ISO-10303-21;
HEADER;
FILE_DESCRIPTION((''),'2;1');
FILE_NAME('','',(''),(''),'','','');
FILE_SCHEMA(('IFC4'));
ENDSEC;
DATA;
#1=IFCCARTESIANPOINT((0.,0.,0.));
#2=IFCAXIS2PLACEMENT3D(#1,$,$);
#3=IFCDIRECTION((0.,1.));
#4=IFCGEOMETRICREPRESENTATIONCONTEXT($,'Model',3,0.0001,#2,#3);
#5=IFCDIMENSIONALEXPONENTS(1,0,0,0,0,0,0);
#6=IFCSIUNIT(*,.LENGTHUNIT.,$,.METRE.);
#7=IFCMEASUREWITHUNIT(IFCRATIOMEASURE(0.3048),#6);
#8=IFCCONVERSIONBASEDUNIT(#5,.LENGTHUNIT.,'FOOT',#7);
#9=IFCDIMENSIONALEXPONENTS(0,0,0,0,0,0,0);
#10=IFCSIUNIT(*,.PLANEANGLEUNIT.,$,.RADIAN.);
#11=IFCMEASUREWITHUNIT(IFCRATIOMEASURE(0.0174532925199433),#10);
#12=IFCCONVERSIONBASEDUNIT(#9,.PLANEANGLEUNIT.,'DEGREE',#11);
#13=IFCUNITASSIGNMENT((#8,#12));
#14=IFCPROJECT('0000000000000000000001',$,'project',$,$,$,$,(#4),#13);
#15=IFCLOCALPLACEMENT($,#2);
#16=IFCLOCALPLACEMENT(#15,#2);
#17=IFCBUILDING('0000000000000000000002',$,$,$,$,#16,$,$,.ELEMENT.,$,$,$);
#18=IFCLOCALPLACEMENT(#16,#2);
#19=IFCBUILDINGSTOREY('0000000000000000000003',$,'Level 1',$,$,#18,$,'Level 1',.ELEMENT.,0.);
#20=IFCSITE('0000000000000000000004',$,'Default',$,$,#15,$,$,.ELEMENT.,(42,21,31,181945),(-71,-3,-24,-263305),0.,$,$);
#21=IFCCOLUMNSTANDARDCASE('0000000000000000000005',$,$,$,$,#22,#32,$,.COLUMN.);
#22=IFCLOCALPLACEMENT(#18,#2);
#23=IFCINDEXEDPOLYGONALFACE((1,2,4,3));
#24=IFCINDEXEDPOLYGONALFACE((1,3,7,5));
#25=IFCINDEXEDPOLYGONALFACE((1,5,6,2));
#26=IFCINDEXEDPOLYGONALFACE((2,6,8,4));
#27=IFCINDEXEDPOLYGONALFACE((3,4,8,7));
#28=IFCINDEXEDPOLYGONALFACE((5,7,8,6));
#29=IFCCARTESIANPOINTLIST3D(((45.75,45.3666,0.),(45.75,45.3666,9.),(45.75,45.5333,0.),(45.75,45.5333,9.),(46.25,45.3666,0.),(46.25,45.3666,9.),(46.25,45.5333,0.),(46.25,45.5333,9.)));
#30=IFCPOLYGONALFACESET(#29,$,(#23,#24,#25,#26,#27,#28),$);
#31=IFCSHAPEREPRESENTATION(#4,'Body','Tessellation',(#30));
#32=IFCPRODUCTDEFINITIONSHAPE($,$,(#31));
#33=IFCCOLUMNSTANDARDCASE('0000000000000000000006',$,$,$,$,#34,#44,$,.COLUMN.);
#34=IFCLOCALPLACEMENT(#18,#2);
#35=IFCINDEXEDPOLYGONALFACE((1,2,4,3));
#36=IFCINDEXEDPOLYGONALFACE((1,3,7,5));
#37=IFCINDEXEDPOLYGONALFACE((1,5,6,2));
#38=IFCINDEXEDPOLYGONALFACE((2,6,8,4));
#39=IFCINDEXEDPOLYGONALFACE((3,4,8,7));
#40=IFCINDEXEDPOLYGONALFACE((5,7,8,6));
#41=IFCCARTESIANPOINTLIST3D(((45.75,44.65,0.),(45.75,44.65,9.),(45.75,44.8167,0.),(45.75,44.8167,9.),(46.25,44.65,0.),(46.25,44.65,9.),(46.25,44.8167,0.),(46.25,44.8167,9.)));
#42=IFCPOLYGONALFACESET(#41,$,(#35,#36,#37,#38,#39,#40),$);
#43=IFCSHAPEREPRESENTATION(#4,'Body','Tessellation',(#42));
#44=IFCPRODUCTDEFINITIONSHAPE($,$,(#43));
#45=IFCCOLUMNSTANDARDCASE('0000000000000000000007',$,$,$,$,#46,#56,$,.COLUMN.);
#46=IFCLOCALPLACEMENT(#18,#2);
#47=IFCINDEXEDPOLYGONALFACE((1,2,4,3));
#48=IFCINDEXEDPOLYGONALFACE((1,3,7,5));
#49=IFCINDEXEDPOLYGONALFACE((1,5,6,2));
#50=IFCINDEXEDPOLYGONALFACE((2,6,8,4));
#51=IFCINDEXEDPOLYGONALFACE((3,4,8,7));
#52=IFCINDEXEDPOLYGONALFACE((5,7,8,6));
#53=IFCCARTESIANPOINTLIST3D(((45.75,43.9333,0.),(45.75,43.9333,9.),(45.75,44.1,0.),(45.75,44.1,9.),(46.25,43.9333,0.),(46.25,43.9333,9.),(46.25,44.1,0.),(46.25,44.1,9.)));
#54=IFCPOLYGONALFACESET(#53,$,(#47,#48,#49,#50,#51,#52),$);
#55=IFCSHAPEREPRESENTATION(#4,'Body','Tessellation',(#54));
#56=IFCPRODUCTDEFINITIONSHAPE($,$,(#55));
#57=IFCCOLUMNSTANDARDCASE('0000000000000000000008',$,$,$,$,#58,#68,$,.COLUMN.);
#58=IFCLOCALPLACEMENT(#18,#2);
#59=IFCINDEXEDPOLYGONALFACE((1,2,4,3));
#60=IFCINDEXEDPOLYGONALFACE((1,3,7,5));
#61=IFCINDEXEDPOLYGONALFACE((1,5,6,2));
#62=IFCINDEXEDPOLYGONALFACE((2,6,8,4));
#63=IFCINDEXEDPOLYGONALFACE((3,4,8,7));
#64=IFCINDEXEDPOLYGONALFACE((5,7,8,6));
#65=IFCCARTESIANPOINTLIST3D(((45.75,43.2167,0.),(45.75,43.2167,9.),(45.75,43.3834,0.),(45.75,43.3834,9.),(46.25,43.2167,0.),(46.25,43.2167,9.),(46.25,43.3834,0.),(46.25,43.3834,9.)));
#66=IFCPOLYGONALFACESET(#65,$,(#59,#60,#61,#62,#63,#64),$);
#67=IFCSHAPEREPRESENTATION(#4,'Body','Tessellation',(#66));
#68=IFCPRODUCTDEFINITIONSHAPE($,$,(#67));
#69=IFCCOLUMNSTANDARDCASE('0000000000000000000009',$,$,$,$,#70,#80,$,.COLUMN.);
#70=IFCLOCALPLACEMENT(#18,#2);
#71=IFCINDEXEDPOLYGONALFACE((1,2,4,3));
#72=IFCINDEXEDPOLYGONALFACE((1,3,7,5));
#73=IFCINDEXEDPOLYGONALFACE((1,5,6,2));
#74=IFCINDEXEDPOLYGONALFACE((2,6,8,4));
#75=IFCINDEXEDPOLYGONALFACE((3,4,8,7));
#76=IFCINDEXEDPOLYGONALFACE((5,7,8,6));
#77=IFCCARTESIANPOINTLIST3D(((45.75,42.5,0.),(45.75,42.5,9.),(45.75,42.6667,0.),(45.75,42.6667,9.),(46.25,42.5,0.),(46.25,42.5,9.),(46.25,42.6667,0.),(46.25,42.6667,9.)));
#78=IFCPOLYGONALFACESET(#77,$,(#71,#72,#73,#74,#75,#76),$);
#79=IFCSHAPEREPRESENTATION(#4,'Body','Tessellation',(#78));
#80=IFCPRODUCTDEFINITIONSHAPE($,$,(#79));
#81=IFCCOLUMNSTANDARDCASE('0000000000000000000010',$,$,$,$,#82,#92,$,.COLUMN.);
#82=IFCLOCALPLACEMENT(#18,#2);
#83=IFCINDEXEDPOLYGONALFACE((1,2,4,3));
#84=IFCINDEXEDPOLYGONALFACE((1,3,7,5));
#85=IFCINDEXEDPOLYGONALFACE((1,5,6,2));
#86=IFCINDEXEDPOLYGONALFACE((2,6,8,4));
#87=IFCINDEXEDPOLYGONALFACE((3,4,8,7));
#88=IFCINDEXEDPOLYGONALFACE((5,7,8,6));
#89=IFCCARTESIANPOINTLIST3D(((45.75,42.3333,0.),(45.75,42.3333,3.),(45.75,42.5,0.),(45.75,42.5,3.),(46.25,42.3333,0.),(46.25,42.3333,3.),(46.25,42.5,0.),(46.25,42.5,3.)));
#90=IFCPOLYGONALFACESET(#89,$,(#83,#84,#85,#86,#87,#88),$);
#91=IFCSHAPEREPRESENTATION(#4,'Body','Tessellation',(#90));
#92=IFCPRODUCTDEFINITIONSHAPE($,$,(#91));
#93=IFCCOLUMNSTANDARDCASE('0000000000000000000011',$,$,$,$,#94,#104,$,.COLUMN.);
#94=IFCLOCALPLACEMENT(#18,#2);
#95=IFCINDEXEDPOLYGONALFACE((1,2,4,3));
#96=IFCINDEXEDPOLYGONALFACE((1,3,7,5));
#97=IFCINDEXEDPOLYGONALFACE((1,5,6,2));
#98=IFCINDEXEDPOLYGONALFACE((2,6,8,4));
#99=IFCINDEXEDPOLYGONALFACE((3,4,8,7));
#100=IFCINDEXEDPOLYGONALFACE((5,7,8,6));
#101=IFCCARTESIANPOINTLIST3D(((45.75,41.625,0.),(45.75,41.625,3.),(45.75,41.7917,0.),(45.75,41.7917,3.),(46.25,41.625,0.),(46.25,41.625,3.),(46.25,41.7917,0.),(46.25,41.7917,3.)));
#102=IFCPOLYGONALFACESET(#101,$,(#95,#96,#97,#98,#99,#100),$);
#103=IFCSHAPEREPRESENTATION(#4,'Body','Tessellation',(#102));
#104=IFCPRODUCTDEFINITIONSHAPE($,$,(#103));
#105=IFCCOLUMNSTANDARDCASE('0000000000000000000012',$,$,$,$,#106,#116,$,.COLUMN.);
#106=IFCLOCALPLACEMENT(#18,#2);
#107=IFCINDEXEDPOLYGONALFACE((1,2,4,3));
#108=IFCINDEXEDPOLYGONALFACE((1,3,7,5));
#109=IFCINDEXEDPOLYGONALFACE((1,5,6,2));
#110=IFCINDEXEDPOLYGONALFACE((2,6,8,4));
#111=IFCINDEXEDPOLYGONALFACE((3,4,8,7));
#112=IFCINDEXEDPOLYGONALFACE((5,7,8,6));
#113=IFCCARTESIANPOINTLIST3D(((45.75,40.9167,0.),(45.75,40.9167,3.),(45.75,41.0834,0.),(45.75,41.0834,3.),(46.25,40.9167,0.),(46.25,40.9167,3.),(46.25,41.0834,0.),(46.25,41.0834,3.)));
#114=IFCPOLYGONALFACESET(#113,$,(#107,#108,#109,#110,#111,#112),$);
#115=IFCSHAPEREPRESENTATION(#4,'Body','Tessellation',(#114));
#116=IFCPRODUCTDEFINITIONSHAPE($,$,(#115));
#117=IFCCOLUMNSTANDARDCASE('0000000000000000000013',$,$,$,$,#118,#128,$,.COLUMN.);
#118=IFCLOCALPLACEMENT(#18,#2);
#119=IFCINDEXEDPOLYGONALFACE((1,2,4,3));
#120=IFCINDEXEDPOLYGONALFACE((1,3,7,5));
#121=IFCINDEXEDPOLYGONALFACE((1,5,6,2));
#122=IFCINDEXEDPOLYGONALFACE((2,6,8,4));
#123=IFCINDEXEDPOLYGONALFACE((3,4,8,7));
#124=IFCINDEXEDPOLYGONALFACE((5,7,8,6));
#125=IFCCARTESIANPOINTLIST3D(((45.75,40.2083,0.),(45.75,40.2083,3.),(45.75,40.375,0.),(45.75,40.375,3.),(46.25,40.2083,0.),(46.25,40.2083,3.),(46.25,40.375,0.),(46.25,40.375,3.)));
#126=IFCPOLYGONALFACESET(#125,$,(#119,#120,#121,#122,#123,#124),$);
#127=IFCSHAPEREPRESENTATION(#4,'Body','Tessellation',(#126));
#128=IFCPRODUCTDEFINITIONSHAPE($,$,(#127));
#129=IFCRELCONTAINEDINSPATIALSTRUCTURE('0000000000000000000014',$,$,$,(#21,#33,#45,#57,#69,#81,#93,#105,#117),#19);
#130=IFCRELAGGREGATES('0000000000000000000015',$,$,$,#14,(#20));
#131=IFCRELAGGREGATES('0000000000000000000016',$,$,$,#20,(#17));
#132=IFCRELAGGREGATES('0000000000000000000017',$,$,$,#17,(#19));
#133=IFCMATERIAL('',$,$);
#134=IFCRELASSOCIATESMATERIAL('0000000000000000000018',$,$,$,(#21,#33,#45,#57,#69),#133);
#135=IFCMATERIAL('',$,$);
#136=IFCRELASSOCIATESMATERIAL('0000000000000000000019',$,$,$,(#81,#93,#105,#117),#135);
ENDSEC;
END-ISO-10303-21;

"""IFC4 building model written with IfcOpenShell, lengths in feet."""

from ifc_helpers import new_model, entity, si_unit, converted_unit, direction, frame, origin, place, context, project, spatial, rectangle, extrude, material, element, save


model = new_model("IFC4")

# Units and contexts
model_context = context("Model", 3, precision=0.0001, world=origin(), true_north=direction((0.0, 1.0)))
ifc_project = project(units=[converted_unit("LENGTHUNIT", "FOOT", entity("IfcRatioMeasure", 0.3048), si_unit("LENGTHUNIT", "METRE"), dimensions=[1, 0, 0, 0, 0, 0, 0]), converted_unit("PLANEANGLEUNIT", "DEGREE", entity("IfcRatioMeasure", 0.0174532925199433), si_unit("PLANEANGLEUNIT", "RADIAN"), dimensions=[0, 0, 0, 0, 0, 0, 0])], contexts=[model_context])

# Site, building, storey
site_placement = place(None, origin())
site = spatial("IfcSite", under=ifc_project, at=site_placement, Name="Default", CompositionType="ELEMENT", RefLatitude=(42, 21, 31, 181945), RefLongitude=(-71, -3, -24, -263305), RefElevation=0.0)
building_placement = place(site_placement, origin())
building = spatial("IfcBuilding", under=site, at=building_placement, CompositionType="ELEMENT")
storey_placement = place(building_placement, origin())
storey = spatial("IfcBuildingStorey", under=building, at=storey_placement, Name="Level 1", LongName="Level 1", CompositionType="ELEMENT", Elevation=0.0)

# Columns
ifc_material_1 = material(Name="")
placement_1 = place(storey_placement, frame((46.0, 46.25, 0.0), z_axis=(0.0, 0.0, 1.0), x_axis=(0.0, -1.0, 0.0)))
for number, where, z_axis, x_axis in (
    (1, (0.8, 0.0, 0.0), (0.0, 0.0, 1.0), (1.0, 0.0, 0.0)),
    (2, (1.5167, 0.0, 0.0), (0.0, 0.0, 1.0), (1.0, 0.0, 0.0)),
    (3, (2.2333, 0.0, 0.0), (0.0, 0.0, 1.0), (1.0, 0.0, 0.0)),
    (4, (2.95, 0.0, 0.0), (0.0, 0.0, 1.0), (1.0, 0.0, 0.0)),
    (5, (3.6667, 0.0, 0.0), (0.0, 0.0, 1.0), (1.0, 0.0, 0.0)),
):
    element("IfcColumnStandardCase", number, at=place(placement_1, frame(where, z_axis=z_axis, x_axis=x_axis)), inside=storey, material=ifc_material_1, PredefinedType="COLUMN", context=model_context, shape_type="SweptSolid", body=[
        extrude(rectangle(XDim=0.1667, YDim=0.5), origin(), (0.0, 0.0, 1.0), 9.0),
    ])
ifc_material_2 = material(Name="")
for number, where, z_axis, x_axis in (
    (6, (3.8334, 0.0, 0.0), (0.0, 0.0, 1.0), (1.0, 0.0, 0.0)),
    (7, (4.5417, 0.0, 0.0), (0.0, 0.0, 1.0), (1.0, 0.0, 0.0)),
    (8, (5.25, 0.0, 0.0), (0.0, 0.0, 1.0), (1.0, 0.0, 0.0)),
    (9, (5.9583, 0.0, 0.0), (0.0, 0.0, 1.0), (1.0, 0.0, 0.0)),
):
    element("IfcColumnStandardCase", number, at=place(placement_1, frame(where, z_axis=z_axis, x_axis=x_axis)), inside=storey, material=ifc_material_2, PredefinedType="COLUMN", context=model_context, shape_type="SweptSolid", body=[
        extrude(rectangle(XDim=0.1667, YDim=0.5), origin(), (0.0, 0.0, 1.0), 3.0),
    ])

save(model, "model.ifc")
